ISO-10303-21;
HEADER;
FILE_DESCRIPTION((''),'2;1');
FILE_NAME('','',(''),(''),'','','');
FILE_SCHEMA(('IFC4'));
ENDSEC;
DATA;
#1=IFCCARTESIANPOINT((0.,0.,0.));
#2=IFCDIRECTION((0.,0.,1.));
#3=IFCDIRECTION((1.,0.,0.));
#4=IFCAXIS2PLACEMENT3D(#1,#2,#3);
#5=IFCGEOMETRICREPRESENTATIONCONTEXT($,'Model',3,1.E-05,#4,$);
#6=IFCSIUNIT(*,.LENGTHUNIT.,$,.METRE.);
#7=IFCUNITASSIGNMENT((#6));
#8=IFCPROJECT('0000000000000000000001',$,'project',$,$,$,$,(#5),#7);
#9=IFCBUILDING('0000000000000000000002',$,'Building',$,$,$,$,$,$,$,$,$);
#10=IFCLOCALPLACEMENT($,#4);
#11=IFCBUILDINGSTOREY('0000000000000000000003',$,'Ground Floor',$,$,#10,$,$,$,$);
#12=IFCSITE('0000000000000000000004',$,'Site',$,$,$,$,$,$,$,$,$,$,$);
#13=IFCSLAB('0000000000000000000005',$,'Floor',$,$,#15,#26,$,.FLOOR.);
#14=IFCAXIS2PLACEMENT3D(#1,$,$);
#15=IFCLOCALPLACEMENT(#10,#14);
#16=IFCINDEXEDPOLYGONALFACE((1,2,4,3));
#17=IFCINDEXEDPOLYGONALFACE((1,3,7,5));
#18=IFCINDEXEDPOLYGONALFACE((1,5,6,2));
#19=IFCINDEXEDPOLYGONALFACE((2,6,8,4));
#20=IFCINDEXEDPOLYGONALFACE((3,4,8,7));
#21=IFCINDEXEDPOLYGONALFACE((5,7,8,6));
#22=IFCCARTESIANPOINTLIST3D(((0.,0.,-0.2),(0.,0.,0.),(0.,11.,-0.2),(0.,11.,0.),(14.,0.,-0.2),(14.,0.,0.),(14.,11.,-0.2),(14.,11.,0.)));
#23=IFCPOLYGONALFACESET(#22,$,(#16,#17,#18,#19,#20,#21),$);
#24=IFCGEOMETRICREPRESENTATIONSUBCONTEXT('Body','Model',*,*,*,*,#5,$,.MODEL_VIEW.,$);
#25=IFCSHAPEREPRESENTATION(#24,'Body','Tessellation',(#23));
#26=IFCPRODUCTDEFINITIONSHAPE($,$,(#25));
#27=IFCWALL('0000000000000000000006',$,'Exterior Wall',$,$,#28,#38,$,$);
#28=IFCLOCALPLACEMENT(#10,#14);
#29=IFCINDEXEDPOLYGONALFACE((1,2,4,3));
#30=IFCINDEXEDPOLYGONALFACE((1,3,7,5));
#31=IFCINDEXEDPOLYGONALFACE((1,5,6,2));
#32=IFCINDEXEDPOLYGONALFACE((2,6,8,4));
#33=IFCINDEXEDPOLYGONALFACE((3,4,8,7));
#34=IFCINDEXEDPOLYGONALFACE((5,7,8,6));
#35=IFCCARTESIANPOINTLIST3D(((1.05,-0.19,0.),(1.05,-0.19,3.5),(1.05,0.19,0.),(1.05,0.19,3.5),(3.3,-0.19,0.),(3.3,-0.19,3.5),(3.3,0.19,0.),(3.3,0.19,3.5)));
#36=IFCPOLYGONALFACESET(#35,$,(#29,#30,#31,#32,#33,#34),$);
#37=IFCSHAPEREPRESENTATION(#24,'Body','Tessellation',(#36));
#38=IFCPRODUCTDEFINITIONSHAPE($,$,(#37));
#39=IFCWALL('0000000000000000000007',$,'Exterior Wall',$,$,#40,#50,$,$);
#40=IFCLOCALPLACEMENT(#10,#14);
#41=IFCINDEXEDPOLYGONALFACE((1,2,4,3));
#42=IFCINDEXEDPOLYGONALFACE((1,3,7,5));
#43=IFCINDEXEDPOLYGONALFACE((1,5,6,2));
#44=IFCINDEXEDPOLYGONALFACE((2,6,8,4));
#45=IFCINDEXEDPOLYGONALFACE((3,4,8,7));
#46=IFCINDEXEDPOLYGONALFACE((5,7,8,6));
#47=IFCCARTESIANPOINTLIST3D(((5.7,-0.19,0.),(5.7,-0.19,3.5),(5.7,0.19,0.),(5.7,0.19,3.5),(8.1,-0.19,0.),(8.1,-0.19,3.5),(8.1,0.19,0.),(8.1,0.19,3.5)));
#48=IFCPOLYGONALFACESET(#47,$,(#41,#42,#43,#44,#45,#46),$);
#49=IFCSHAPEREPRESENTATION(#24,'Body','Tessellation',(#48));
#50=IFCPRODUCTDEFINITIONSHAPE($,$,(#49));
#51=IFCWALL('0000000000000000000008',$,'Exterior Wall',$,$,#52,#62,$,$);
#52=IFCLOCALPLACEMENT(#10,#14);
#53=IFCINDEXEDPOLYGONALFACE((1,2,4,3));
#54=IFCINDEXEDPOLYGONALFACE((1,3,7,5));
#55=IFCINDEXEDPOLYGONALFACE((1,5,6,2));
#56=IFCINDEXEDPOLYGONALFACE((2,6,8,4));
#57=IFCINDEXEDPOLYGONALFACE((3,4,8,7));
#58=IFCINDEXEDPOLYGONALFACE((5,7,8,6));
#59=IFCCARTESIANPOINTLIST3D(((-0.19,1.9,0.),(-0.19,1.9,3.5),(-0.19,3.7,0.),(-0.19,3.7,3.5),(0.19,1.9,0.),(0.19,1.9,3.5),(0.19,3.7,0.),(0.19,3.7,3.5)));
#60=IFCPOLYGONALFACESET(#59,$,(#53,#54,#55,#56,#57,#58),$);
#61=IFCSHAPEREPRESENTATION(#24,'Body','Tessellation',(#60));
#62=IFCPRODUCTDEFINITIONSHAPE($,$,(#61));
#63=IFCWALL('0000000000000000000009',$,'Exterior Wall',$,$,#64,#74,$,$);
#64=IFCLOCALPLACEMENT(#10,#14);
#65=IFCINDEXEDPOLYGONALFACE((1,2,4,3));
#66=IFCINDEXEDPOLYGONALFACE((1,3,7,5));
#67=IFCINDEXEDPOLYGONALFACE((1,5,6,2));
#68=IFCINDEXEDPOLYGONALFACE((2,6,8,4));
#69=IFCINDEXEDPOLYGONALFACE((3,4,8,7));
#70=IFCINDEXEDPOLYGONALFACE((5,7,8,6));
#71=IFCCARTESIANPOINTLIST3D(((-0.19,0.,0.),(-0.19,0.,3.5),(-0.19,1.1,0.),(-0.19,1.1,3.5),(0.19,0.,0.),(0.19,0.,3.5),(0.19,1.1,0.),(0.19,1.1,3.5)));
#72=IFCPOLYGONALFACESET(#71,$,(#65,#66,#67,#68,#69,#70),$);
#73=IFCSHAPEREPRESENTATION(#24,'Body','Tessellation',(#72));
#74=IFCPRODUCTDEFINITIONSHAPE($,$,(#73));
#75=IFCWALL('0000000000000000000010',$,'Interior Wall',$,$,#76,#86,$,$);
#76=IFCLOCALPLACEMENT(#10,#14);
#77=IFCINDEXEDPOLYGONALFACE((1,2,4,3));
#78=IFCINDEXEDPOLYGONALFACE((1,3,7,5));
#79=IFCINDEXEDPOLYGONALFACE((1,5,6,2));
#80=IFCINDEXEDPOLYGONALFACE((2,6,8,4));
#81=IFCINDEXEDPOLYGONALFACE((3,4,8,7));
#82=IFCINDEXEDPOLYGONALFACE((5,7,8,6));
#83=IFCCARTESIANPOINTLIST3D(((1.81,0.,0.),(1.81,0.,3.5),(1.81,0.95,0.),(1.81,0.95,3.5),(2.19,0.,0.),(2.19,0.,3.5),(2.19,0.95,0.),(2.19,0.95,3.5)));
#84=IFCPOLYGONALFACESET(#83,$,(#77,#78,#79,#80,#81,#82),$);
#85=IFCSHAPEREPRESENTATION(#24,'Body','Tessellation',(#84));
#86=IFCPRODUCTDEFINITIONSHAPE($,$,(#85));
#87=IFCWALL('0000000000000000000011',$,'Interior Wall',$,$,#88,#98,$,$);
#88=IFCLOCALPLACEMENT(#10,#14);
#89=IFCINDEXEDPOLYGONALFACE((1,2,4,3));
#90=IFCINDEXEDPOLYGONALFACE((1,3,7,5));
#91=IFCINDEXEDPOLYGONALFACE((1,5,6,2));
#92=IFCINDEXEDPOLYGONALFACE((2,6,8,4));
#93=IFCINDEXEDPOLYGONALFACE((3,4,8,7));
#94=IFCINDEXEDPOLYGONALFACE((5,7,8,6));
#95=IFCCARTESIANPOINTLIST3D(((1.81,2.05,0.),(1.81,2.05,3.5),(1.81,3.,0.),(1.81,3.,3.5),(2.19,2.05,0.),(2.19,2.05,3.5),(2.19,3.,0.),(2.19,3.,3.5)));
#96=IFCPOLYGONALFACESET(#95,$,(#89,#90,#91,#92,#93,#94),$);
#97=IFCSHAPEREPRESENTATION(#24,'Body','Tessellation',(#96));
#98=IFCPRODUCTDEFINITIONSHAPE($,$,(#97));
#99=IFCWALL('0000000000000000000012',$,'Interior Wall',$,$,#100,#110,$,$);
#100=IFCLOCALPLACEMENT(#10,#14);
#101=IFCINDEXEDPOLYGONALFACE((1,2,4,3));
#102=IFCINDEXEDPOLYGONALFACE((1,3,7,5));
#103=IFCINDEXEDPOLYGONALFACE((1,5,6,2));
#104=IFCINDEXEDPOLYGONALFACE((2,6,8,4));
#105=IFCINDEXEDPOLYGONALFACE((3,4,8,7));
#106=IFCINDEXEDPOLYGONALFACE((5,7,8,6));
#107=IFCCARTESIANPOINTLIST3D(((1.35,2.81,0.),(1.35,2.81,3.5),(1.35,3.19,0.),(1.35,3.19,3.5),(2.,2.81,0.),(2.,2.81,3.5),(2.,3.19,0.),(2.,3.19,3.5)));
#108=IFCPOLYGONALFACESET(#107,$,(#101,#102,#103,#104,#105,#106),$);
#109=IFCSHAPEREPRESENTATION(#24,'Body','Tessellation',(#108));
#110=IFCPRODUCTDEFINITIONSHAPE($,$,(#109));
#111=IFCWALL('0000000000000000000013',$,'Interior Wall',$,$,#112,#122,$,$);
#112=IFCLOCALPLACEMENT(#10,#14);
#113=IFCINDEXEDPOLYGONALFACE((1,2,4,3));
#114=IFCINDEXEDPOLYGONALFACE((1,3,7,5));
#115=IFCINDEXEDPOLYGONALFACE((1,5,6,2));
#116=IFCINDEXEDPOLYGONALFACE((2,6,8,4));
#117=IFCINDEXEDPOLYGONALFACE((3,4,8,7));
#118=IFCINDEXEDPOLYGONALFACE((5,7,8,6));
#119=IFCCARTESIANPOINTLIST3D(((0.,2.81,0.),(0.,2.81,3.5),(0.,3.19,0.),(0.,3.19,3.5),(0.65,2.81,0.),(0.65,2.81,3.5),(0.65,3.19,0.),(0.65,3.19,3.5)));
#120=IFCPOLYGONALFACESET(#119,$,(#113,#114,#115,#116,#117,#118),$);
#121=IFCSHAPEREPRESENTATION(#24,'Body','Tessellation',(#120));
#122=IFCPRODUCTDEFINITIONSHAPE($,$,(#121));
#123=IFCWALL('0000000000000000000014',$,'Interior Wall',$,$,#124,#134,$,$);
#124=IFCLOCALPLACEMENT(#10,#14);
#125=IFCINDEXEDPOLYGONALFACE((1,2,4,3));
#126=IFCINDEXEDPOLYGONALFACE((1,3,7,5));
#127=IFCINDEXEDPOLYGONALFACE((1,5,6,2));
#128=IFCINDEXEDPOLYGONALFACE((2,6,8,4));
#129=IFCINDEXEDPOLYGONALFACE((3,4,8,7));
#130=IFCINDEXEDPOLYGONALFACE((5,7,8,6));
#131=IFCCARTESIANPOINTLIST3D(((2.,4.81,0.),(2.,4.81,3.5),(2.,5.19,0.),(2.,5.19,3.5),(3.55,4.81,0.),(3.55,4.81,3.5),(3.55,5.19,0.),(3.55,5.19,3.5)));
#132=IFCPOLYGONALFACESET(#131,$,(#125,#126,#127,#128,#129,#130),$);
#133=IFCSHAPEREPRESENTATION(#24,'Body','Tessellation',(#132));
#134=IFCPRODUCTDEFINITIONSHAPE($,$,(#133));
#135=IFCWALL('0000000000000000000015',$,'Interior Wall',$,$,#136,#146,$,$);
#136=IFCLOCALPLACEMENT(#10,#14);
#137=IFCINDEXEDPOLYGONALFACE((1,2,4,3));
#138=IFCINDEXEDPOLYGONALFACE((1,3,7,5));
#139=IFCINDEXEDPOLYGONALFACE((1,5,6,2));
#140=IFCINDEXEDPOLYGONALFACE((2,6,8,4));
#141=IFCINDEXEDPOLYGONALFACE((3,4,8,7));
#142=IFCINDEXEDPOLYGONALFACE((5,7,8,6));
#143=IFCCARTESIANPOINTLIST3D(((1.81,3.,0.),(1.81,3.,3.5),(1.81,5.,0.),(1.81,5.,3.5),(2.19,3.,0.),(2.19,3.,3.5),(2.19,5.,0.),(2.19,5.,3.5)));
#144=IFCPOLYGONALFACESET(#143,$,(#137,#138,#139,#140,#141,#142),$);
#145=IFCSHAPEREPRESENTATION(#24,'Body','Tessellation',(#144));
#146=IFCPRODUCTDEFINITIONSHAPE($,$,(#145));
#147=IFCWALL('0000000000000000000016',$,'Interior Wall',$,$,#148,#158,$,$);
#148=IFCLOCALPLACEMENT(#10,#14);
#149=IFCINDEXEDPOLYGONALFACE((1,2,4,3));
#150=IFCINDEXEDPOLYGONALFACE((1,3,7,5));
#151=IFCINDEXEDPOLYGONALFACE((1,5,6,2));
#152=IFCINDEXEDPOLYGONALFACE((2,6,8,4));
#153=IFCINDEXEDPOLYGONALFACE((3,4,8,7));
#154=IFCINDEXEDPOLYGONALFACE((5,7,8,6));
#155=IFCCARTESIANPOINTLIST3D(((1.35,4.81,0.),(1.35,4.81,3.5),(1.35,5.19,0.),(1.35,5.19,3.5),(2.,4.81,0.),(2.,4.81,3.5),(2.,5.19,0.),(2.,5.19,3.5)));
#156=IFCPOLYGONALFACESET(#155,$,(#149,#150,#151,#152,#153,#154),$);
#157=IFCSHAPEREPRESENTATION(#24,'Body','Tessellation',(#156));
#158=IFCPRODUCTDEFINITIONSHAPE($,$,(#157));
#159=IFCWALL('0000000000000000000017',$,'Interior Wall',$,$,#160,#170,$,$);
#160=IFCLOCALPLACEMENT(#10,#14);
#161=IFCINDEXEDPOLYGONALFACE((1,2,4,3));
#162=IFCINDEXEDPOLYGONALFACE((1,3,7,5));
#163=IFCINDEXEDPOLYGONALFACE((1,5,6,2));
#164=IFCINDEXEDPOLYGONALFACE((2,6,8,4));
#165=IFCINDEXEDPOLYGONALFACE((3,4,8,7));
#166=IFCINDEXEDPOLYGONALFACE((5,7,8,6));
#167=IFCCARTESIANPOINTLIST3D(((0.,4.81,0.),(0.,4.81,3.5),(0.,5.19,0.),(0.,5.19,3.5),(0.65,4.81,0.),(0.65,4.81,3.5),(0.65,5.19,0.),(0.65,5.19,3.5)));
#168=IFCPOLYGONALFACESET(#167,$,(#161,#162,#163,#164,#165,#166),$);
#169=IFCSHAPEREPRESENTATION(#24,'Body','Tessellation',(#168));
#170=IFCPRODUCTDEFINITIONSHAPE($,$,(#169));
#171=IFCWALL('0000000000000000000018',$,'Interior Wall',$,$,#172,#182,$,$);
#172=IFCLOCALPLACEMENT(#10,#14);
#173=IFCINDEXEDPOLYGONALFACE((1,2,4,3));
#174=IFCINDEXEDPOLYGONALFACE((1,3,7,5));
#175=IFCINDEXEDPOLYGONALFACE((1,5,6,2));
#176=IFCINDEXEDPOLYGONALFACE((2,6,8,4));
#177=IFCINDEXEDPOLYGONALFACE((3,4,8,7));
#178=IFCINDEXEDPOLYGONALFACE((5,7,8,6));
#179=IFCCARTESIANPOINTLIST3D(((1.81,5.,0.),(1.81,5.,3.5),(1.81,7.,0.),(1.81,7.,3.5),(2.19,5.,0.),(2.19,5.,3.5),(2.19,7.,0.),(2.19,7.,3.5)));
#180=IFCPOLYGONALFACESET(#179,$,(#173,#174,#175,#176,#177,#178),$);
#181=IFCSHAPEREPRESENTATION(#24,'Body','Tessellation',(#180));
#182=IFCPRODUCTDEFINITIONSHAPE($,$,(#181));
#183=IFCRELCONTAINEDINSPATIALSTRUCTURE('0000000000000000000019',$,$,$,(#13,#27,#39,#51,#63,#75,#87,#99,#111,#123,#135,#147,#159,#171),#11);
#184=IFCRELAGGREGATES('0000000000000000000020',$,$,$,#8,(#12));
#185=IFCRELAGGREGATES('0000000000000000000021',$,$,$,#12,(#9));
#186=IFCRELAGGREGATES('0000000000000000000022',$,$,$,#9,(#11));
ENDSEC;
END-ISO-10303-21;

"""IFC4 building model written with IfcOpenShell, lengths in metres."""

from ifc_helpers import new_model, si_unit, frame, origin_with_axes, place, context, subcontext, project, spatial, indexed_curve, outline, extrude, element, save


model = new_model("IFC4")

# Units and contexts
model_context = context("Model", 3, precision=1e-05, world=origin_with_axes())
body_context = subcontext(model_context, "Body", "Model", "MODEL_VIEW")
ifc_project = project(units=[si_unit("LENGTHUNIT", "METRE")], contexts=[model_context])

# Site, building, storey
site = spatial("IfcSite", under=ifc_project, Name="Site")
building = spatial("IfcBuilding", under=site, Name="Building")
storey_placement = place(None, origin_with_axes())
storey = spatial("IfcBuildingStorey", under=building, at=storey_placement, Name="Ground Floor")

# Slab
slab_placement = place(storey_placement, frame((0.0, 0.0, -0.2), z_axis=(0.0, 0.0, 1.0), x_axis=(1.0, 0.0, 0.0)))
element("IfcSlab", 1, at=slab_placement, inside=storey, Name="Floor", PredefinedType="FLOOR", context=body_context, shape_type="SweptSolid", body=[
    extrude(outline(indexed_curve([(0.0, 0.0), (14.0, 0.0), (14.0, 11.0), (0.0, 11.0)])), None, (0.0, 0.0, 1.0), 0.2),
])

# Walls
wall_1_placement = place(storey_placement, frame((1.05, 0.0, 0.0), z_axis=(0.0, 0.0, 1.0), x_axis=(1.0, 0.0, 0.0)))
element("IfcWall", 2, at=wall_1_placement, inside=storey, Name="Exterior Wall", context=body_context, shape_type="SweptSolid", body=[
    extrude(outline(indexed_curve([(0.0, 0.0), (0.0, 0.38), (2.25, 0.38), (2.25, 0.0), (0.0, 0.0)], self_intersect=False)), frame((0.0, -0.19, 0.0), z_axis=(0.0, 0.0, 1.0), x_axis=(1.0, 0.0, 0.0)), (0.0, 0.0, 1.0), 3.5),
])
wall_2_placement = place(storey_placement, frame((5.7, 0.0, 0.0), z_axis=(0.0, 0.0, 1.0), x_axis=(1.0, 0.0, 0.0)))
element("IfcWall", 3, at=wall_2_placement, inside=storey, Name="Exterior Wall", context=body_context, shape_type="SweptSolid", body=[
    extrude(outline(indexed_curve([(0.0, 0.0), (0.0, 0.38), (2.4, 0.38), (2.4, 0.0), (0.0, 0.0)], self_intersect=False)), frame((0.0, -0.19, 0.0), z_axis=(0.0, 0.0, 1.0), x_axis=(1.0, 0.0, 0.0)), (0.0, 0.0, 1.0), 3.5),
])
wall_3_placement = place(storey_placement, frame((0.0, 3.7, 0.0), z_axis=(0.0, 0.0, 1.0), x_axis=(0.0, -1.0, 0.0)))
element("IfcWall", 4, at=wall_3_placement, inside=storey, Name="Exterior Wall", context=body_context, shape_type="SweptSolid", body=[
    extrude(outline(indexed_curve([(0.0, 0.0), (0.0, 0.38), (1.8, 0.38), (1.8, 0.0), (0.0, 0.0)], self_intersect=False)), frame((0.0, -0.19, 0.0), z_axis=(0.0, 0.0, 1.0), x_axis=(1.0, 0.0, 0.0)), (0.0, 0.0, 1.0), 3.5),
])
wall_4_placement = place(storey_placement, frame((0.0, 1.1, 0.0), z_axis=(0.0, 0.0, 1.0), x_axis=(0.0, -1.0, 0.0)))
element("IfcWall", 5, at=wall_4_placement, inside=storey, Name="Exterior Wall", context=body_context, shape_type="SweptSolid", body=[
    extrude(outline(indexed_curve([(0.0, 0.0), (0.0, 0.38), (1.1, 0.38), (1.1, 0.0), (0.0, 0.0)], self_intersect=False)), frame((0.0, -0.19, 0.0), z_axis=(0.0, 0.0, 1.0), x_axis=(1.0, 0.0, 0.0)), (0.0, 0.0, 1.0), 3.5),
])
wall_5_placement = place(storey_placement, frame((2.0, 0.0, 0.0), z_axis=(0.0, 0.0, 1.0), x_axis=(0.0, 1.0, 0.0)))
element("IfcWall", 6, at=wall_5_placement, inside=storey, Name="Interior Wall", context=body_context, shape_type="SweptSolid", body=[
    extrude(outline(indexed_curve([(0.0, 0.0), (0.0, 0.38), (0.95, 0.38), (0.95, 0.0), (0.0, 0.0)], self_intersect=False)), frame((0.0, -0.19, 0.0), z_axis=(0.0, 0.0, 1.0), x_axis=(1.0, 0.0, 0.0)), (0.0, 0.0, 1.0), 3.5),
])
wall_6_placement = place(storey_placement, frame((2.0, 2.05, 0.0), z_axis=(0.0, 0.0, 1.0), x_axis=(0.0, 1.0, 0.0)))
element("IfcWall", 7, at=wall_6_placement, inside=storey, Name="Interior Wall", context=body_context, shape_type="SweptSolid", body=[
    extrude(outline(indexed_curve([(0.0, 0.0), (0.0, 0.38), (0.95, 0.38), (0.95, 0.0), (0.0, 0.0)], self_intersect=False)), frame((0.0, -0.19, 0.0), z_axis=(0.0, 0.0, 1.0), x_axis=(1.0, 0.0, 0.0)), (0.0, 0.0, 1.0), 3.5),
])
for number, where, z_axis, x_axis, name in (
    (8, (2.0, 3.0, 0.0), (0.0, 0.0, 1.0), (-1.0, 0.0, 0.0), "Interior Wall"),
    (9, (0.65, 3.0, 0.0), (0.0, 0.0, 1.0), (-1.0, 0.0, 0.0), "Interior Wall"),
):
    element("IfcWall", number, at=place(storey_placement, frame(where, z_axis=z_axis, x_axis=x_axis)), inside=storey, Name=name, context=body_context, shape_type="SweptSolid", body=[
        extrude(outline(indexed_curve([(0.0, 0.0), (0.0, 0.38), (0.65, 0.38), (0.65, 0.0), (0.0, 0.0)], self_intersect=False)), frame((0.0, -0.19, 0.0), z_axis=(0.0, 0.0, 1.0), x_axis=(1.0, 0.0, 0.0)), (0.0, 0.0, 1.0), 3.5),
    ])
wall_7_placement = place(storey_placement, frame((3.55, 5.0, 0.0), z_axis=(0.0, 0.0, 1.0), x_axis=(-1.0, 0.0, 0.0)))
element("IfcWall", 10, at=wall_7_placement, inside=storey, Name="Interior Wall", context=body_context, shape_type="SweptSolid", body=[
    extrude(outline(indexed_curve([(0.0, 0.0), (0.0, 0.38), (1.55, 0.38), (1.55, 0.0), (0.0, 0.0)], self_intersect=False)), frame((0.0, -0.19, 0.0), z_axis=(0.0, 0.0, 1.0), x_axis=(1.0, 0.0, 0.0)), (0.0, 0.0, 1.0), 3.5),
])
wall_8_placement = place(storey_placement, frame((2.0, 5.0, 0.0), z_axis=(0.0, 0.0, 1.0), x_axis=(0.0, -1.0, 0.0)))
element("IfcWall", 11, at=wall_8_placement, inside=storey, Name="Interior Wall", context=body_context, shape_type="SweptSolid", body=[
    extrude(outline(indexed_curve([(0.0, 0.0), (0.0, 0.38), (2.0, 0.38), (2.0, 0.0), (0.0, 0.0)], self_intersect=False)), frame((0.0, -0.19, 0.0), z_axis=(0.0, 0.0, 1.0), x_axis=(1.0, 0.0, 0.0)), (0.0, 0.0, 1.0), 3.5),
])
for number, where, z_axis, x_axis, name in (
    (12, (2.0, 5.0, 0.0), (0.0, 0.0, 1.0), (-1.0, 0.0, 0.0), "Interior Wall"),
    (13, (0.65, 5.0, 0.0), (0.0, 0.0, 1.0), (-1.0, 0.0, 0.0), "Interior Wall"),
):
    element("IfcWall", number, at=place(storey_placement, frame(where, z_axis=z_axis, x_axis=x_axis)), inside=storey, Name=name, context=body_context, shape_type="SweptSolid", body=[
        extrude(outline(indexed_curve([(0.0, 0.0), (0.0, 0.38), (0.65, 0.38), (0.65, 0.0), (0.0, 0.0)], self_intersect=False)), frame((0.0, -0.19, 0.0), z_axis=(0.0, 0.0, 1.0), x_axis=(1.0, 0.0, 0.0)), (0.0, 0.0, 1.0), 3.5),
    ])
wall_9_placement = place(storey_placement, frame((2.0, 5.0, 0.0), z_axis=(0.0, 0.0, 1.0), x_axis=(0.0, 1.0, 0.0)))
element("IfcWall", 14, at=wall_9_placement, inside=storey, Name="Interior Wall", context=body_context, shape_type="SweptSolid", body=[
    extrude(outline(indexed_curve([(0.0, 0.0), (0.0, 0.38), (2.0, 0.38), (2.0, 0.0), (0.0, 0.0)], self_intersect=False)), frame((0.0, -0.19, 0.0), z_axis=(0.0, 0.0, 1.0), x_axis=(1.0, 0.0, 0.0)), (0.0, 0.0, 1.0), 3.5),
])

save(model, "model.ifc")
